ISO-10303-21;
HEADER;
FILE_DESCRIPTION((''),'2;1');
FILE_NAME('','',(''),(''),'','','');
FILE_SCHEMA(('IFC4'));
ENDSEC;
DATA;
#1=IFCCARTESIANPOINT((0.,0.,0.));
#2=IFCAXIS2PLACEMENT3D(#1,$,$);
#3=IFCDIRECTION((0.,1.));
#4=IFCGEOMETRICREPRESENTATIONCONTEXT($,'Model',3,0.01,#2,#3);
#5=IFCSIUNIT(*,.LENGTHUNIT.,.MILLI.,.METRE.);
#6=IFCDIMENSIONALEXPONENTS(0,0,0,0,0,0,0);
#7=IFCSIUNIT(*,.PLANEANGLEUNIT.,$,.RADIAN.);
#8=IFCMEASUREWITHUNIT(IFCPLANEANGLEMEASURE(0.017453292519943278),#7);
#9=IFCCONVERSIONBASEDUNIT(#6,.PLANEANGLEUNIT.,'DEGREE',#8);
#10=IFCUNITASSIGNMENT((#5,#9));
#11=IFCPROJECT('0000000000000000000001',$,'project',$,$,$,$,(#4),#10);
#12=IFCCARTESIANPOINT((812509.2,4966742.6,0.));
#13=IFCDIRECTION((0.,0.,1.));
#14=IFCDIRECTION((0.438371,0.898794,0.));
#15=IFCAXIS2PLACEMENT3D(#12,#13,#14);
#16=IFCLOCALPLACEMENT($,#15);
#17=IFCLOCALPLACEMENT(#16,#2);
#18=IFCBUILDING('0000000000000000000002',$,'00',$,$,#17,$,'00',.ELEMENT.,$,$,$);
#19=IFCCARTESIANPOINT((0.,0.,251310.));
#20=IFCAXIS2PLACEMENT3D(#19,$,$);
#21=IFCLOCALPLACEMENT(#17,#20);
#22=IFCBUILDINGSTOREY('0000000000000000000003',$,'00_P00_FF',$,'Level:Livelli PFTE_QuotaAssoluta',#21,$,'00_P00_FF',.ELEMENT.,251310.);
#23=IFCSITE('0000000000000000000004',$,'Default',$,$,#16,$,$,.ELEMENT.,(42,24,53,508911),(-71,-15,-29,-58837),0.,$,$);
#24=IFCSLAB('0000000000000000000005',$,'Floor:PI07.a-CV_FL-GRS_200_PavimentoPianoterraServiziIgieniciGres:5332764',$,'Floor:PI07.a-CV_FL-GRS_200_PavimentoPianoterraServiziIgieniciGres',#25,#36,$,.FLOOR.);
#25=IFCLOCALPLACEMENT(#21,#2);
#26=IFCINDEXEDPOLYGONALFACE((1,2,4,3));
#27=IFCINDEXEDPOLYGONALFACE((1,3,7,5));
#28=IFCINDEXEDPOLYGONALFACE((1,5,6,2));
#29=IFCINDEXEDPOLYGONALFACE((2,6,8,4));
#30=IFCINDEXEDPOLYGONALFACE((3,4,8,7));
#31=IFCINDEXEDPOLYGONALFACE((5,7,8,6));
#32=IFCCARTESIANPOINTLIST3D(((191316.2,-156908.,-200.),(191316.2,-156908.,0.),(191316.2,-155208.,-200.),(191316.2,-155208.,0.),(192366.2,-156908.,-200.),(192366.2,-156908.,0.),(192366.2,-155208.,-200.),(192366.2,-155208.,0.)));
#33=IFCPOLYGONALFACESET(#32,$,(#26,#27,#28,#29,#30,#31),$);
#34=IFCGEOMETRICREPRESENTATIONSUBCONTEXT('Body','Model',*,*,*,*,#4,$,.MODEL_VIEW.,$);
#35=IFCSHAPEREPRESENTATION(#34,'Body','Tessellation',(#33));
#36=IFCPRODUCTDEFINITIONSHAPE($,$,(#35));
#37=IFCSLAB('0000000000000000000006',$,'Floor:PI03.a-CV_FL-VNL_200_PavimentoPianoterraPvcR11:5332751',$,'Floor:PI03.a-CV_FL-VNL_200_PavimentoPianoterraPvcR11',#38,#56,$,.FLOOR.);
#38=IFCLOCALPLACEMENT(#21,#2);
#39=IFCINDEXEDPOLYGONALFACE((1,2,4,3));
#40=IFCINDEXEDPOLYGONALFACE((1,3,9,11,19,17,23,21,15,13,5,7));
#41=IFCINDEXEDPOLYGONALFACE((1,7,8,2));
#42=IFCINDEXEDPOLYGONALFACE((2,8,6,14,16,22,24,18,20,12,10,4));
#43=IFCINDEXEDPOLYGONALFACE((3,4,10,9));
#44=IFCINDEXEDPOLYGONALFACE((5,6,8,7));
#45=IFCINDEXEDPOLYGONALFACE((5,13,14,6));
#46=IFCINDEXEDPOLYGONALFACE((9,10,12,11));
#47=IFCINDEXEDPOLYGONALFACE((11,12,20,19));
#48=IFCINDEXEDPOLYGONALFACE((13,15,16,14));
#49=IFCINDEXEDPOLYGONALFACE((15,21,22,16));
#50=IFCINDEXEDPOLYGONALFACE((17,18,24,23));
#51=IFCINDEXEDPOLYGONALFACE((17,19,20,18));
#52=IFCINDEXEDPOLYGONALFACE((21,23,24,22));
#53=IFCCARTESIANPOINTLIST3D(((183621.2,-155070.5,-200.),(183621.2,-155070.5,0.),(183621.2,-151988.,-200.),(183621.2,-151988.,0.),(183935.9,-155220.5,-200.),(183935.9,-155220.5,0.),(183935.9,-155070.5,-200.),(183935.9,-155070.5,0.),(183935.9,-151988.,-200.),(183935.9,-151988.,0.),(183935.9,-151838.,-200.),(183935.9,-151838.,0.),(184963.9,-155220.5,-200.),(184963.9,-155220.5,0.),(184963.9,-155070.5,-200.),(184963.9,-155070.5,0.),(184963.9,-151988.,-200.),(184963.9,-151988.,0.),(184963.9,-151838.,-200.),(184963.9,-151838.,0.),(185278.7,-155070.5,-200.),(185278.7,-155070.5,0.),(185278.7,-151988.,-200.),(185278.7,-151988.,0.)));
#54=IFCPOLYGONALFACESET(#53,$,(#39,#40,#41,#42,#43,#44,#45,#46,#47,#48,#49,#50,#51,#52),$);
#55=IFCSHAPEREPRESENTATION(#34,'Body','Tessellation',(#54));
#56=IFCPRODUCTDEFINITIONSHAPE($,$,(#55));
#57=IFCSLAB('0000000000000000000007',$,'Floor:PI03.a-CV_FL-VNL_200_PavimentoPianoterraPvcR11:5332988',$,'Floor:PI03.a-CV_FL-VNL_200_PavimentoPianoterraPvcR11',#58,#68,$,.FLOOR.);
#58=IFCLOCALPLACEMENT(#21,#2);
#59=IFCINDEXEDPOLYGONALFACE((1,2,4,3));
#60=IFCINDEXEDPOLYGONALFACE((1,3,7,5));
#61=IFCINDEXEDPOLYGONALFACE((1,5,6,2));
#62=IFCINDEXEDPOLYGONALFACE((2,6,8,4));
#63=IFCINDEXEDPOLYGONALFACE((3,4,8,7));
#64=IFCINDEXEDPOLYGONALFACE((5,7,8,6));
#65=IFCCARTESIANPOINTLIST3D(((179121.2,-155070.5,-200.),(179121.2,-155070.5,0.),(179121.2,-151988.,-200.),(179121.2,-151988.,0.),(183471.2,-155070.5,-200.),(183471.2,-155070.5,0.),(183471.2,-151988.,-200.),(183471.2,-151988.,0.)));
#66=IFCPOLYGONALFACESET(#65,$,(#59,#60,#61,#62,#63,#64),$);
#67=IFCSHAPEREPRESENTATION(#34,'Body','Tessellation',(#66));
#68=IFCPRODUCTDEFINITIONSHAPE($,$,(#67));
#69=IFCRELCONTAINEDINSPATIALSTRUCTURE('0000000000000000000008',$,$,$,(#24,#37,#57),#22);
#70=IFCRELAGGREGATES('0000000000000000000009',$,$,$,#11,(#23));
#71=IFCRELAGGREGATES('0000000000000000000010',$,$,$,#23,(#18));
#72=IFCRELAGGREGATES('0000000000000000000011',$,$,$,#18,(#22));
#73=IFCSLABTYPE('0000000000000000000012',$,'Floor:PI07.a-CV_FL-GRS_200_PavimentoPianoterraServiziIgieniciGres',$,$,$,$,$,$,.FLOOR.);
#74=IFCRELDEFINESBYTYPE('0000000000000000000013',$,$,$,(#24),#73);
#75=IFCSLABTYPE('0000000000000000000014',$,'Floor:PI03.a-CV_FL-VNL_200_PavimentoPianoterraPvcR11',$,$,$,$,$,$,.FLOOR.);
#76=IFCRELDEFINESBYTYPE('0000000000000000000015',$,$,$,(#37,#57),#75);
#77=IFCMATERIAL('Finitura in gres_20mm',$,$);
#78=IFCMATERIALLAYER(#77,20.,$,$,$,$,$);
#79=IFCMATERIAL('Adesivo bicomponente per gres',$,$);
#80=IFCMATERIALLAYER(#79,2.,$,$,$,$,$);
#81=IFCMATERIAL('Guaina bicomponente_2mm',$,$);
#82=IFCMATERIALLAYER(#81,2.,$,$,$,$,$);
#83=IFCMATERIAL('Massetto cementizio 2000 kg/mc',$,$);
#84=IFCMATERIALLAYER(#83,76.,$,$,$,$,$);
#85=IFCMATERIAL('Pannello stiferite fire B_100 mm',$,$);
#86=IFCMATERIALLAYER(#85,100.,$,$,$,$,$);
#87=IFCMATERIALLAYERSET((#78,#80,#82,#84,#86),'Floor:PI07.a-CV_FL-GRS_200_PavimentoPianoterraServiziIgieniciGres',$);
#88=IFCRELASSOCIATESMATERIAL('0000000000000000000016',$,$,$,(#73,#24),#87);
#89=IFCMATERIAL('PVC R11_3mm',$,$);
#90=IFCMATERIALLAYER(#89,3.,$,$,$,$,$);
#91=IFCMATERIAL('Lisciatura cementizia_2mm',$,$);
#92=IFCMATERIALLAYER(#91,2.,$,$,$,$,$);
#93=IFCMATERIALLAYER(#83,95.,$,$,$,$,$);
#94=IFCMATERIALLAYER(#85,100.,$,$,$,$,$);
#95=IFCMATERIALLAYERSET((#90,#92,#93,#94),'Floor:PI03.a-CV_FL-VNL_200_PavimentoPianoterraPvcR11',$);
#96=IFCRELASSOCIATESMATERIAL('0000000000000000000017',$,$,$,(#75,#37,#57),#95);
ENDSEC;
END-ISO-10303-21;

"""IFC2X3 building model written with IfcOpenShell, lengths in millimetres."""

from ifc_helpers import new_model, entity, si_unit, converted_unit, direction, frame, frame_2d, origin, place, context, subcontext, project, spatial, polyline, rectangle, outline, extrude, material, layer, layer_set, layer_usage, type_object, element, save


model = new_model("IFC2X3")

# Units and contexts
model_context = context("Model", 3, precision=0.01, world=origin(), true_north=direction((0.0, 1.0)))
body_context = subcontext(model_context, "Body", "Model", "MODEL_VIEW")
ifc_project = project(units=[si_unit("LENGTHUNIT", "METRE", prefix="MILLI"), converted_unit("PLANEANGLEUNIT", "DEGREE", entity("IfcPlaneAngleMeasure", 0.017453292519943278), si_unit("PLANEANGLEUNIT", "RADIAN"), dimensions=[0, 0, 0, 0, 0, 0, 0])], contexts=[model_context])

# Site, building, storey
site_placement = place(None, frame((812509.2, 4966742.6, 0.0), z_axis=(0.0, 0.0, 1.0), x_axis=(0.438371, 0.898794, 0.0)))
site = spatial("IfcSite", under=ifc_project, at=site_placement, Name="Default", CompositionType="ELEMENT", RefLatitude=(42, 24, 53, 508911), RefLongitude=(-71, -15, -29, -58837), RefElevation=0.0)
building_placement = place(site_placement, origin())
building = spatial("IfcBuilding", under=site, at=building_placement, Name="00", LongName="00", CompositionType="ELEMENT")
storey_placement = place(building_placement, frame((0.0, 0.0, 251310.0)))
storey = spatial("IfcBuildingStorey", under=building, at=storey_placement, Name="00_P00_FF", ObjectType="Level:Livelli PFTE_QuotaAssoluta", LongName="00_P00_FF", CompositionType="ELEMENT", Elevation=251310.0)

# Shared definitions
ifc_material_1 = material(Name="Pannello stiferite fire B_100 mm")

# Shared definitions
ifc_material_2 = material(Name="Lisciatura cementizia_2mm")
ifc_material_3 = material(Name="Massetto cementizio 2000 kg/mc")
ifc_material_4 = material(Name="Finitura in gres_20mm")
ifc_layer_1 = layer(ifc_material_4, 20.0)
ifc_material_5 = material(Name="Adesivo bicomponente per gres")
ifc_layer_2 = layer(ifc_material_5, 2.0)
ifc_material_6 = material(Name="Guaina bicomponente_2mm")
ifc_layer_3 = layer(ifc_material_6, 2.0)
ifc_layer_4 = layer(ifc_material_3, 76.0)
ifc_layer_5 = layer(ifc_material_1, 100.0)
ifc_layer_set_1 = layer_set([ifc_layer_1, ifc_layer_2, ifc_layer_3, ifc_layer_4, ifc_layer_5], Name="Floor:PI07.a-CV_FL-GRS_200_PavimentoPianoterraServiziIgieniciGres")
slab_type_1 = type_object("IfcSlabType", Name="Floor:PI07.a-CV_FL-GRS_200_PavimentoPianoterraServiziIgieniciGres", PredefinedType="FLOOR", material=ifc_layer_set_1)

# Slabs
ifc_layer_usage_1 = layer_usage(ifc_layer_set_1, "AXIS3", "POSITIVE", 0.0)
slab_1_placement = place(storey_placement, origin())
element("IfcSlab", 1, at=slab_1_placement, inside=storey, type_object=slab_type_1, material=ifc_layer_usage_1, Name="Floor:PI07.a-CV_FL-GRS_200_PavimentoPianoterraServiziIgieniciGres:5332764", ObjectType="Floor:PI07.a-CV_FL-GRS_200_PavimentoPianoterraServiziIgieniciGres", PredefinedType="FLOOR", context=body_context, shape_type="SweptSolid", body=[
    extrude(rectangle(XDim=1050.0, YDim=1700.0, at=frame_2d((0.0, 0.0), x_axis=(1.0, 0.0))), frame((191841.2, -156058.0, 0.0), z_axis=(0.0, 0.0, -1.0), x_axis=(1.0, 0.0, 0.0)), (0.0, 0.0, 1.0), 200.0),
])
ifc_material_7 = material(Name="PVC R11_3mm")
ifc_layer_6 = layer(ifc_material_7, 3.0)
ifc_layer_7 = layer(ifc_material_2, 2.0)
ifc_layer_8 = layer(ifc_material_3, 95.0)
ifc_layer_9 = layer(ifc_material_1, 100.0)
ifc_layer_set_2 = layer_set([ifc_layer_6, ifc_layer_7, ifc_layer_8, ifc_layer_9], Name="Floor:PI03.a-CV_FL-VNL_200_PavimentoPianoterraPvcR11")
slab_type_2 = type_object("IfcSlabType", Name="Floor:PI03.a-CV_FL-VNL_200_PavimentoPianoterraPvcR11", PredefinedType="FLOOR", material=ifc_layer_set_2)
ifc_layer_usage_2 = layer_usage(ifc_layer_set_2, "AXIS3", "POSITIVE", 0.0)
slab_2_placement = place(storey_placement, origin())
element("IfcSlab", 2, at=slab_2_placement, inside=storey, type_object=slab_type_2, material=ifc_layer_usage_2, Name="Floor:PI03.a-CV_FL-VNL_200_PavimentoPianoterraPvcR11:5332751", ObjectType="Floor:PI03.a-CV_FL-VNL_200_PavimentoPianoterraPvcR11", PredefinedType="FLOOR", context=body_context, shape_type="SweptSolid", body=[
    extrude(outline(polyline([(-1541.3, -828.7), (1541.2, -828.7), (1541.2, -514.0), (1691.3, -514.0), (1691.3, 514.0), (1541.2, 514.0), (1541.2, 828.7), (-1541.3, 828.7), (-1541.3, 514.0), (-1691.3, 514.0), (-1691.3, -514.0), (-1541.3, -514.0), (-1541.3, -828.7)])), frame((184449.9, -153529.2, 0.0), z_axis=(0.0, 0.0, -1.0), x_axis=(0.0, 1.0, 0.0)), (0.0, 0.0, 1.0), 200.0),
])

# Slab
ifc_layer_usage_3 = layer_usage(ifc_layer_set_2, "AXIS3", "POSITIVE", 0.0)
slab_3_placement = place(storey_placement, origin())
element("IfcSlab", 3, at=slab_3_placement, inside=storey, type_object=slab_type_2, material=ifc_layer_usage_3, Name="Floor:PI03.a-CV_FL-VNL_200_PavimentoPianoterraPvcR11:5332988", ObjectType="Floor:PI03.a-CV_FL-VNL_200_PavimentoPianoterraPvcR11", PredefinedType="FLOOR", context=body_context, shape_type="SweptSolid", body=[
    extrude(rectangle(XDim=3082.5, YDim=4350.0, at=frame_2d((0.0, 0.0), x_axis=(1.0, 0.0))), frame((181296.2, -153529.2, 0.0), z_axis=(0.0, 0.0, -1.0), x_axis=(0.0, 1.0, 0.0)), (0.0, 0.0, 1.0), 200.0),
])

save(model, "model.ifc")
